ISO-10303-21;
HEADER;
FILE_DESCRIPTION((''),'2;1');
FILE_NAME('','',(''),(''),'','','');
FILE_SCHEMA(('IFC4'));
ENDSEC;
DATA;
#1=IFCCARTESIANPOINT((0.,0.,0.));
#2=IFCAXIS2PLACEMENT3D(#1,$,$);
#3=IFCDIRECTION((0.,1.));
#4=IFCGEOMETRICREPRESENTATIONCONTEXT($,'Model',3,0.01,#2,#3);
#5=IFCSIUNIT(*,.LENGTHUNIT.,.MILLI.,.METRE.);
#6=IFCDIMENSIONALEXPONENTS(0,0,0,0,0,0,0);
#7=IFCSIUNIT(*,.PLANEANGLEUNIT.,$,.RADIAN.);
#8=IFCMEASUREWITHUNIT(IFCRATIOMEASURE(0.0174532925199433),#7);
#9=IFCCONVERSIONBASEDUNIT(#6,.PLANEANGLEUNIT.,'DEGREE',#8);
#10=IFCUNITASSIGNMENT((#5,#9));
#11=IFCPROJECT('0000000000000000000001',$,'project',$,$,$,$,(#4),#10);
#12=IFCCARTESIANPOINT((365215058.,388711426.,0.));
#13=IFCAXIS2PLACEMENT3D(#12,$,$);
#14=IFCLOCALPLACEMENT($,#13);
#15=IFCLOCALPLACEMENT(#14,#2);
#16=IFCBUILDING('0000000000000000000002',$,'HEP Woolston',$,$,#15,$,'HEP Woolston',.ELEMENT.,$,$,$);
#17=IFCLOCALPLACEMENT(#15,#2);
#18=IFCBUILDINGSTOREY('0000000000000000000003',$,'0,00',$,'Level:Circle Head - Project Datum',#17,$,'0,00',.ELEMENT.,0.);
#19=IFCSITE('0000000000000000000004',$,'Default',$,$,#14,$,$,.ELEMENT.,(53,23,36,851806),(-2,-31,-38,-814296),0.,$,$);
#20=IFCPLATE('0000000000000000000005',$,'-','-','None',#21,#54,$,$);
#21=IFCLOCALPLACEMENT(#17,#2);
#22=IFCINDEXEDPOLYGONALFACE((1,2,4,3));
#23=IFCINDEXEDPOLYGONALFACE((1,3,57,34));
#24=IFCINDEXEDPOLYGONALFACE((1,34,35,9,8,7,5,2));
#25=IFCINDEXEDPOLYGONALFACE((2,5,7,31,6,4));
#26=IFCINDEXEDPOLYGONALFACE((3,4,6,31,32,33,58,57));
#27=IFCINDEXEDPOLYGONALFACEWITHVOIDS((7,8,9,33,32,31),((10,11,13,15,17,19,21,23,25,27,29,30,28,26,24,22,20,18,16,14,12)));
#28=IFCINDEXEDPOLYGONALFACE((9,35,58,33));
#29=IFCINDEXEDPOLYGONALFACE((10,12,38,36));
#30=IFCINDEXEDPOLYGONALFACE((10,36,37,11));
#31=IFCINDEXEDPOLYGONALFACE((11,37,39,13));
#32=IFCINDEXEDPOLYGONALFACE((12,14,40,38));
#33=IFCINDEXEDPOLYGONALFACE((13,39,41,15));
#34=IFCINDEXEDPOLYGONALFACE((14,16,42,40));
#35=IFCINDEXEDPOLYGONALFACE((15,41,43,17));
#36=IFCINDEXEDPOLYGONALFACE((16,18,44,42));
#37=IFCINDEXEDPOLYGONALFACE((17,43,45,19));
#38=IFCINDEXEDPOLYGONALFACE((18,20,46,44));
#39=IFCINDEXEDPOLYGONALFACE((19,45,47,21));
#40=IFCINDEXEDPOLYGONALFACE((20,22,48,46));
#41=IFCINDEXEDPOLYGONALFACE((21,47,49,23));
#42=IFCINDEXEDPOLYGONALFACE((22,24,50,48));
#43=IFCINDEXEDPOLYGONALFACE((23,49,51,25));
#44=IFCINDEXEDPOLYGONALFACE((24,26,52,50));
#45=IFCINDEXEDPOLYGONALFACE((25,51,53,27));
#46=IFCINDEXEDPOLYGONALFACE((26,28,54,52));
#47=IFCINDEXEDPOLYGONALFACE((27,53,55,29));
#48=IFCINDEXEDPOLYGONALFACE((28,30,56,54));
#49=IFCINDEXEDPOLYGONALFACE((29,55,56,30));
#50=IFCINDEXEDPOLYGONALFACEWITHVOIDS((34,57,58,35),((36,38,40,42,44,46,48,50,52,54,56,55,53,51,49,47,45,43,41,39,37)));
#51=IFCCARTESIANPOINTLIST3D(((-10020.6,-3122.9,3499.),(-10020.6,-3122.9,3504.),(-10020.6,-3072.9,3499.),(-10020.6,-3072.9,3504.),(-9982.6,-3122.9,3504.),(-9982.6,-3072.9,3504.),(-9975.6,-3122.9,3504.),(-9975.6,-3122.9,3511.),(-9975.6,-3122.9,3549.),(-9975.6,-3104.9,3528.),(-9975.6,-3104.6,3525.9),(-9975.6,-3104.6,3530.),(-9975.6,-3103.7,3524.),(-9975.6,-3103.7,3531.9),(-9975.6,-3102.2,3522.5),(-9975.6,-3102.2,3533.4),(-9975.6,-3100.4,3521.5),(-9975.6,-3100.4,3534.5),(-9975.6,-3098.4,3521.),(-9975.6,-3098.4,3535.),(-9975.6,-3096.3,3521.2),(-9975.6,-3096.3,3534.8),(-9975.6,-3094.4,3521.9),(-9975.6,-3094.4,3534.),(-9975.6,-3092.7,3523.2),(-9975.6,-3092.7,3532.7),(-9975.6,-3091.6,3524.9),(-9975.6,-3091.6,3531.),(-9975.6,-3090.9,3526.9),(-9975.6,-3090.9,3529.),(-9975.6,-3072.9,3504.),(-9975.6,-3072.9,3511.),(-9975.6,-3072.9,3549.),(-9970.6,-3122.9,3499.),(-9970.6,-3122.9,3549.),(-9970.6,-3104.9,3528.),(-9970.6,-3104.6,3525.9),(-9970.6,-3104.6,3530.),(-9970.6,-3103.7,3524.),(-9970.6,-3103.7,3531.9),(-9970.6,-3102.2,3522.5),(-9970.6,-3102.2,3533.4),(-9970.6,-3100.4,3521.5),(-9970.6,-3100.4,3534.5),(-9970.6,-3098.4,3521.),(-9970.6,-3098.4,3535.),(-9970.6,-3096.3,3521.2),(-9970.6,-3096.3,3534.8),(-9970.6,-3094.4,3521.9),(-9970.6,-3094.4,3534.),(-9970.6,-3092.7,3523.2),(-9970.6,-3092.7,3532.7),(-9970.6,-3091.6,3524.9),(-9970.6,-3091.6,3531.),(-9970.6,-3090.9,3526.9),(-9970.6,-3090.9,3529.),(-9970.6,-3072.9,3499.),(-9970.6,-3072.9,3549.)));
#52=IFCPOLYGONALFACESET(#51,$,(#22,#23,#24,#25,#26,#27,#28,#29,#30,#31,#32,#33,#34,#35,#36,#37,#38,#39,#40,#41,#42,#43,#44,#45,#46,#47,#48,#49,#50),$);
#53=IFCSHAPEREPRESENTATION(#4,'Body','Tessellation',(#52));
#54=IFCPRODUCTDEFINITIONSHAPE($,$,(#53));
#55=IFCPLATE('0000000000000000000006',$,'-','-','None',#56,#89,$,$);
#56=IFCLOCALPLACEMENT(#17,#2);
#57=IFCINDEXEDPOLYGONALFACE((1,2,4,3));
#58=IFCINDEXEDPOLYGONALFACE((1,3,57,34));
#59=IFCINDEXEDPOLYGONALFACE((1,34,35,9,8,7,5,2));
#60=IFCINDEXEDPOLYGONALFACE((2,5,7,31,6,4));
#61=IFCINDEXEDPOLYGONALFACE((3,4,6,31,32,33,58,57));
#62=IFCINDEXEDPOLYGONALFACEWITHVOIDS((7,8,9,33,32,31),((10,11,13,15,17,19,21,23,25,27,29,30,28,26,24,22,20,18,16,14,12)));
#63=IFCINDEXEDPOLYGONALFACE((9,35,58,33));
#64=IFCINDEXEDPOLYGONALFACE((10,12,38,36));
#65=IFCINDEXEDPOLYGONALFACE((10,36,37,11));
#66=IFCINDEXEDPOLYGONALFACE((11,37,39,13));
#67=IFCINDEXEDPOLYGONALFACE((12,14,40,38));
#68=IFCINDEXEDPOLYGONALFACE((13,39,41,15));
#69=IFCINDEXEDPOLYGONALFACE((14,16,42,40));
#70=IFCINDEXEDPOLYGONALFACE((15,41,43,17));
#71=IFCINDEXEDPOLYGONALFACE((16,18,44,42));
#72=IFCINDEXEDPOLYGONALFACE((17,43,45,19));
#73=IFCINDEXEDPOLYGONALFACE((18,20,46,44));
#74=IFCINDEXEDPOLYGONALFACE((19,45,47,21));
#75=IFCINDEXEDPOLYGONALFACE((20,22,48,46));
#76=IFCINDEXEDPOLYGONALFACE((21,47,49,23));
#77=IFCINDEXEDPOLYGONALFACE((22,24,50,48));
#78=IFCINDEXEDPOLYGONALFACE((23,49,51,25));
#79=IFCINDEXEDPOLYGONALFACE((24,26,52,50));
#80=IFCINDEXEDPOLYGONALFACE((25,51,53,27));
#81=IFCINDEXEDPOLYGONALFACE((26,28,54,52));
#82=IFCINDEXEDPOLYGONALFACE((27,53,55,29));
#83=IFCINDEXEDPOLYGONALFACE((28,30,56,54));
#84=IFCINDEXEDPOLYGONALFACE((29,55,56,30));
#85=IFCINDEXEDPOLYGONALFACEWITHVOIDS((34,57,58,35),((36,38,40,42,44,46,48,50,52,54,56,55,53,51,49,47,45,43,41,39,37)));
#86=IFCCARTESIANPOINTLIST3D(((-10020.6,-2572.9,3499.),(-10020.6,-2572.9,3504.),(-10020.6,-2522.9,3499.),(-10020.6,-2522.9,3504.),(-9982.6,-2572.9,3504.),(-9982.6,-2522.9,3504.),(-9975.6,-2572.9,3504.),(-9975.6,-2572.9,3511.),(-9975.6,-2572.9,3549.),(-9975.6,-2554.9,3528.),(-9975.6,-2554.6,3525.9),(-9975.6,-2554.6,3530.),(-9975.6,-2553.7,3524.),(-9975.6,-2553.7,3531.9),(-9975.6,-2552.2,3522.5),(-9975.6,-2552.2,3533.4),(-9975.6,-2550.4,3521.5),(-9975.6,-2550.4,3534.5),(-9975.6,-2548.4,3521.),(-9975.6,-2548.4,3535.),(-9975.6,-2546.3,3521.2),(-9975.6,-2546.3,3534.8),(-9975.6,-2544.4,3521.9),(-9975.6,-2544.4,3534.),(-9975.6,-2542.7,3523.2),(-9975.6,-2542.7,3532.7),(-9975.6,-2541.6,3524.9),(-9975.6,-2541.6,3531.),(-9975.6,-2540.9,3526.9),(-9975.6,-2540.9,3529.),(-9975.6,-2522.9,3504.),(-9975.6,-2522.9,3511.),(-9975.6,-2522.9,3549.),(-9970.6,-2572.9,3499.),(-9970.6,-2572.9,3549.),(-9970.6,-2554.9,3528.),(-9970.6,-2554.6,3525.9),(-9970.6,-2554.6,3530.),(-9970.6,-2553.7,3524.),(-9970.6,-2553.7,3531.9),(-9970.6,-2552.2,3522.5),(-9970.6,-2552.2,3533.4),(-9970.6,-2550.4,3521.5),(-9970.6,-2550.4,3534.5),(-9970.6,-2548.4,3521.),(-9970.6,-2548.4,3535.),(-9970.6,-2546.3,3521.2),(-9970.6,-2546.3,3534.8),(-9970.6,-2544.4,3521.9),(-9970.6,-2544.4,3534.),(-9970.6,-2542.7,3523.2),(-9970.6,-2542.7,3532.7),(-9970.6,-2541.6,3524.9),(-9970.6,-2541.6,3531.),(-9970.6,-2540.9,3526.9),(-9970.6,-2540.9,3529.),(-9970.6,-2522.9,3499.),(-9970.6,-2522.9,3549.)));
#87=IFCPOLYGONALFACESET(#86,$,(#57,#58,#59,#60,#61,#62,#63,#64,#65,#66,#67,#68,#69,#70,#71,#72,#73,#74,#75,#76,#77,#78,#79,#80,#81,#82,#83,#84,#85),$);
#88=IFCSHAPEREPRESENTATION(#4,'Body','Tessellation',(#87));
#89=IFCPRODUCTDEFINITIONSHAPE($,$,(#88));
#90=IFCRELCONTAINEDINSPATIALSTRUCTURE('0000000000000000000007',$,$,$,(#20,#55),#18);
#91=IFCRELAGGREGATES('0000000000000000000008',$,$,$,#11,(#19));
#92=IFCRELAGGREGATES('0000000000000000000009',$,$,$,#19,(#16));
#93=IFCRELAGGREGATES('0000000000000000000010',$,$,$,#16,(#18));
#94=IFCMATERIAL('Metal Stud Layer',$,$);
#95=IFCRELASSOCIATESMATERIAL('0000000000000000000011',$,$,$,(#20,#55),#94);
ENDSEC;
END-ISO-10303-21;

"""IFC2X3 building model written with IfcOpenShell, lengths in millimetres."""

from ifc_helpers import new_model, entity, si_unit, converted_unit, point, direction, frame, frame_2d, origin, origin_with_axes, origin_2d_with_axis, place, context, project, spatial, polyline, circle_curve, line_curve, trimmed, segment, composite_curve, circle, outline, extrude, material, element, save


model = new_model("IFC2X3")

# Units and contexts
model_context = context("Model", 3, precision=0.01, world=origin(), true_north=direction((0.0, 1.0)))
ifc_project = project(units=[si_unit("LENGTHUNIT", "METRE", prefix="MILLI"), converted_unit("PLANEANGLEUNIT", "DEGREE", entity("IfcRatioMeasure", 0.0174532925199433), si_unit("PLANEANGLEUNIT", "RADIAN"), dimensions=[0, 0, 0, 0, 0, 0, 0])], contexts=[model_context])

# Site, building, storey
site_placement = place(None, frame((365215058.0, 388711426.0, 0.0)))
site = spatial("IfcSite", under=ifc_project, at=site_placement, Name="Default", CompositionType="ELEMENT", RefLatitude=(53, 23, 36, 851806), RefLongitude=(-2, -31, -38, -814296), RefElevation=0.0)
building_placement = place(site_placement, origin())
building = spatial("IfcBuilding", under=site, at=building_placement, Name="HEP Woolston", LongName="HEP Woolston", CompositionType="ELEMENT")
storey_placement = place(building_placement, origin())
storey = spatial("IfcBuildingStorey", under=building, at=storey_placement, Name="0,00", ObjectType="Level:Circle Head - Project Datum", LongName="0,00", CompositionType="ELEMENT", Elevation=0.0)

# Plates, openings
ifc_material = material(Name="Metal Stud Layer")
plate_1_placement = place(storey_placement, frame((-9970.6, -3122.9, 3499.0), z_axis=(0.0, 1.0, 0.0), x_axis=(-1.0, 0.0, 0.0)))
plate_1 = element("IfcPlate", 1, at=plate_1_placement, inside=storey, material=ifc_material, Name="-", Description="-", ObjectType="None", context=model_context, shape_type="SweptSolid", body=[
    extrude(outline(polyline([(0.0, 0.0), (50.0, 0.0), (50.0, 5.0), (5.0, 5.0), (5.0, 50.0), (0.0, 50.0), (0.0, 0.0)])), origin_with_axes(), (0.0, 0.0, 1.0), 50.0),
])
opening_1_placement = place(plate_1_placement, frame((0.0, 0.0, 0.0), z_axis=(0.0, 0.0, 1.0), x_axis=(1.0, 0.0, 0.0)))
element("IfcOpeningElement", 2, at=opening_1_placement, cuts=plate_1, ObjectType="Opening", context=model_context, shape_type="SweptSolid", body=[
    extrude(outline(composite_curve([segment(trimmed(line_curve((50.0, 5.0), (1.0, 0.0), 3.532613), [point((50.0, 5.0))], [point((46.5, 5.0))], True, "CARTESIAN"), True, "CONTINUOUS"), segment(trimmed(circle_curve(frame_2d((46.5, 1.5), x_axis=(-1.0, 0.0)), 3.5), [point((46.5, 5.0))], [point((50.0, 1.5))], False, "CARTESIAN"), True, "CONTINUOUS"), segment(trimmed(line_curve((50.0, 1.5), (0.0, -1.0), 3.532613), [point((50.0, 1.5))], [point((50.0, 5.0))], True, "CARTESIAN"), True, "CONTINUOUS")], self_intersect="UNKNOWN")), origin(), (0.0, 0.0, 1.0), 50.0),
])
opening_2_placement = place(plate_1_placement, origin_with_axes())
element("IfcOpeningElement", 3, at=opening_2_placement, cuts=plate_1, ObjectType="Opening", context=model_context, shape_type="SweptSolid", body=[
    extrude(outline(composite_curve([segment(trimmed(line_curve((5.0, 5.0), (0.0, -1.0), 7.046301), [point((5.0, 5.0))], [point((5.0, 12.0))], False, "CARTESIAN"), True, "CONTINUOUS"), segment(trimmed(circle_curve(frame_2d((12.0, 12.0), x_axis=(1.0, 0.0)), 7.0), [point((5.0, 12.0))], [point((12.0, 5.0))], True, "CARTESIAN"), True, "CONTINUOUS"), segment(trimmed(line_curve((12.0, 5.0), (1.0, 0.0), 7.046301), [point((12.0, 5.0))], [point((5.0, 5.0))], False, "CARTESIAN"), True, "CONTINUOUS")], self_intersect="UNKNOWN")), origin(), (0.0, 0.0, 1.0), 50.0),
])
opening_3_placement = place(plate_1_placement, frame((0.0, 0.0, 0.0), z_axis=(0.0, 0.0, 1.0), x_axis=(1.0, 0.0, 0.0)))
element("IfcOpeningElement", 4, at=opening_3_placement, cuts=plate_1, ObjectType="Opening", context=model_context, shape_type="SweptSolid", body=[
    extrude(outline(composite_curve([segment(trimmed(line_curve((5.0, 50.0), (1.0, 0.0), 3.4874), [point((5.0, 50.0))], [point((1.5, 50.0))], True, "CARTESIAN"), True, "CONTINUOUS"), segment(trimmed(circle_curve(frame_2d((1.5, 46.5), x_axis=(-1.0, 0.0)), 3.5), [point((1.5, 50.0))], [point((5.0, 46.5))], False, "CARTESIAN"), True, "CONTINUOUS"), segment(trimmed(line_curve((5.0, 46.5), (0.0, -1.0), 3.4874), [point((5.0, 46.5))], [point((5.0, 50.0))], True, "CARTESIAN"), True, "CONTINUOUS")], self_intersect="UNKNOWN")), origin(), (0.0, 0.0, 1.0), 50.0),
])
opening_4_placement = place(plate_1_placement, frame((-0.5, 29.0, 25.0), z_axis=(1.0, 0.0, 0.0), x_axis=(0.0, 0.0, -1.0)))
element("IfcOpeningElement", 5, at=opening_4_placement, cuts=plate_1, ObjectType="Opening", context=model_context, shape_type="SweptSolid", body=[
    extrude(circle(Radius=7.0, at=origin_2d_with_axis()), origin(), (0.0, 0.0, 1.0), 6.0),
])
plate_2_placement = place(storey_placement, frame((-9970.6, -2572.9, 3499.0), z_axis=(0.0, 1.0, 0.0), x_axis=(-1.0, 0.0, 0.0)))
plate_2 = element("IfcPlate", 6, at=plate_2_placement, inside=storey, material=ifc_material, Name="-", Description="-", ObjectType="None", context=model_context, shape_type="SweptSolid", body=[
    extrude(outline(polyline([(0.0, 0.0), (50.0, 0.0), (50.0, 5.0), (5.0, 5.0), (5.0, 50.0), (0.0, 50.0), (0.0, 0.0)])), origin_with_axes(), (0.0, 0.0, 1.0), 50.0),
])
opening_5_placement = place(plate_2_placement, frame((0.0, 0.0, 0.0), z_axis=(0.0, 0.0, 1.0), x_axis=(1.0, 0.0, 0.0)))
element("IfcOpeningElement", 7, at=opening_5_placement, cuts=plate_2, ObjectType="Opening", context=model_context, shape_type="SweptSolid", body=[
    extrude(outline(composite_curve([segment(trimmed(line_curve((50.0, 5.0), (1.0, 0.0), 3.532613), [point((50.0, 5.0))], [point((46.5, 5.0))], True, "CARTESIAN"), True, "CONTINUOUS"), segment(trimmed(circle_curve(frame_2d((46.5, 1.5), x_axis=(-1.0, 0.0)), 3.5), [point((46.5, 5.0))], [point((50.0, 1.5))], False, "CARTESIAN"), True, "CONTINUOUS"), segment(trimmed(line_curve((50.0, 1.5), (0.0, -1.0), 3.532613), [point((50.0, 1.5))], [point((50.0, 5.0))], True, "CARTESIAN"), True, "CONTINUOUS")], self_intersect="UNKNOWN")), origin(), (0.0, 0.0, 1.0), 50.0),
])
opening_6_placement = place(plate_2_placement, origin_with_axes())
element("IfcOpeningElement", 8, at=opening_6_placement, cuts=plate_2, ObjectType="Opening", context=model_context, shape_type="SweptSolid", body=[
    extrude(outline(composite_curve([segment(trimmed(line_curve((5.0, 5.0), (0.0, -1.0), 7.046301), [point((5.0, 5.0))], [point((5.0, 12.0))], False, "CARTESIAN"), True, "CONTINUOUS"), segment(trimmed(circle_curve(frame_2d((12.0, 12.0), x_axis=(1.0, 0.0)), 7.0), [point((5.0, 12.0))], [point((12.0, 5.0))], True, "CARTESIAN"), True, "CONTINUOUS"), segment(trimmed(line_curve((12.0, 5.0), (1.0, 0.0), 7.046301), [point((12.0, 5.0))], [point((5.0, 5.0))], False, "CARTESIAN"), True, "CONTINUOUS")], self_intersect="UNKNOWN")), origin(), (0.0, 0.0, 1.0), 50.0),
])
opening_7_placement = place(plate_2_placement, frame((0.0, 0.0, 0.0), z_axis=(0.0, 0.0, 1.0), x_axis=(1.0, 0.0, 0.0)))
element("IfcOpeningElement", 9, at=opening_7_placement, cuts=plate_2, ObjectType="Opening", context=model_context, shape_type="SweptSolid", body=[
    extrude(outline(composite_curve([segment(trimmed(line_curve((5.0, 50.0), (1.0, 0.0), 3.4874), [point((5.0, 50.0))], [point((1.5, 50.0))], True, "CARTESIAN"), True, "CONTINUOUS"), segment(trimmed(circle_curve(frame_2d((1.5, 46.5), x_axis=(-1.0, 0.0)), 3.5), [point((1.5, 50.0))], [point((5.0, 46.5))], False, "CARTESIAN"), True, "CONTINUOUS"), segment(trimmed(line_curve((5.0, 46.5), (0.0, -1.0), 3.4874), [point((5.0, 46.5))], [point((5.0, 50.0))], True, "CARTESIAN"), True, "CONTINUOUS")], self_intersect="UNKNOWN")), origin(), (0.0, 0.0, 1.0), 50.0),
])
opening_8_placement = place(plate_2_placement, frame((-0.5, 29.0, 25.0), z_axis=(1.0, 0.0, 0.0), x_axis=(0.0, 0.0, -1.0)))
element("IfcOpeningElement", 10, at=opening_8_placement, cuts=plate_2, ObjectType="Opening", context=model_context, shape_type="SweptSolid", body=[
    extrude(circle(Radius=7.0, at=origin_2d_with_axis()), origin(), (0.0, 0.0, 1.0), 6.0),
])

save(model, "model.ifc")
